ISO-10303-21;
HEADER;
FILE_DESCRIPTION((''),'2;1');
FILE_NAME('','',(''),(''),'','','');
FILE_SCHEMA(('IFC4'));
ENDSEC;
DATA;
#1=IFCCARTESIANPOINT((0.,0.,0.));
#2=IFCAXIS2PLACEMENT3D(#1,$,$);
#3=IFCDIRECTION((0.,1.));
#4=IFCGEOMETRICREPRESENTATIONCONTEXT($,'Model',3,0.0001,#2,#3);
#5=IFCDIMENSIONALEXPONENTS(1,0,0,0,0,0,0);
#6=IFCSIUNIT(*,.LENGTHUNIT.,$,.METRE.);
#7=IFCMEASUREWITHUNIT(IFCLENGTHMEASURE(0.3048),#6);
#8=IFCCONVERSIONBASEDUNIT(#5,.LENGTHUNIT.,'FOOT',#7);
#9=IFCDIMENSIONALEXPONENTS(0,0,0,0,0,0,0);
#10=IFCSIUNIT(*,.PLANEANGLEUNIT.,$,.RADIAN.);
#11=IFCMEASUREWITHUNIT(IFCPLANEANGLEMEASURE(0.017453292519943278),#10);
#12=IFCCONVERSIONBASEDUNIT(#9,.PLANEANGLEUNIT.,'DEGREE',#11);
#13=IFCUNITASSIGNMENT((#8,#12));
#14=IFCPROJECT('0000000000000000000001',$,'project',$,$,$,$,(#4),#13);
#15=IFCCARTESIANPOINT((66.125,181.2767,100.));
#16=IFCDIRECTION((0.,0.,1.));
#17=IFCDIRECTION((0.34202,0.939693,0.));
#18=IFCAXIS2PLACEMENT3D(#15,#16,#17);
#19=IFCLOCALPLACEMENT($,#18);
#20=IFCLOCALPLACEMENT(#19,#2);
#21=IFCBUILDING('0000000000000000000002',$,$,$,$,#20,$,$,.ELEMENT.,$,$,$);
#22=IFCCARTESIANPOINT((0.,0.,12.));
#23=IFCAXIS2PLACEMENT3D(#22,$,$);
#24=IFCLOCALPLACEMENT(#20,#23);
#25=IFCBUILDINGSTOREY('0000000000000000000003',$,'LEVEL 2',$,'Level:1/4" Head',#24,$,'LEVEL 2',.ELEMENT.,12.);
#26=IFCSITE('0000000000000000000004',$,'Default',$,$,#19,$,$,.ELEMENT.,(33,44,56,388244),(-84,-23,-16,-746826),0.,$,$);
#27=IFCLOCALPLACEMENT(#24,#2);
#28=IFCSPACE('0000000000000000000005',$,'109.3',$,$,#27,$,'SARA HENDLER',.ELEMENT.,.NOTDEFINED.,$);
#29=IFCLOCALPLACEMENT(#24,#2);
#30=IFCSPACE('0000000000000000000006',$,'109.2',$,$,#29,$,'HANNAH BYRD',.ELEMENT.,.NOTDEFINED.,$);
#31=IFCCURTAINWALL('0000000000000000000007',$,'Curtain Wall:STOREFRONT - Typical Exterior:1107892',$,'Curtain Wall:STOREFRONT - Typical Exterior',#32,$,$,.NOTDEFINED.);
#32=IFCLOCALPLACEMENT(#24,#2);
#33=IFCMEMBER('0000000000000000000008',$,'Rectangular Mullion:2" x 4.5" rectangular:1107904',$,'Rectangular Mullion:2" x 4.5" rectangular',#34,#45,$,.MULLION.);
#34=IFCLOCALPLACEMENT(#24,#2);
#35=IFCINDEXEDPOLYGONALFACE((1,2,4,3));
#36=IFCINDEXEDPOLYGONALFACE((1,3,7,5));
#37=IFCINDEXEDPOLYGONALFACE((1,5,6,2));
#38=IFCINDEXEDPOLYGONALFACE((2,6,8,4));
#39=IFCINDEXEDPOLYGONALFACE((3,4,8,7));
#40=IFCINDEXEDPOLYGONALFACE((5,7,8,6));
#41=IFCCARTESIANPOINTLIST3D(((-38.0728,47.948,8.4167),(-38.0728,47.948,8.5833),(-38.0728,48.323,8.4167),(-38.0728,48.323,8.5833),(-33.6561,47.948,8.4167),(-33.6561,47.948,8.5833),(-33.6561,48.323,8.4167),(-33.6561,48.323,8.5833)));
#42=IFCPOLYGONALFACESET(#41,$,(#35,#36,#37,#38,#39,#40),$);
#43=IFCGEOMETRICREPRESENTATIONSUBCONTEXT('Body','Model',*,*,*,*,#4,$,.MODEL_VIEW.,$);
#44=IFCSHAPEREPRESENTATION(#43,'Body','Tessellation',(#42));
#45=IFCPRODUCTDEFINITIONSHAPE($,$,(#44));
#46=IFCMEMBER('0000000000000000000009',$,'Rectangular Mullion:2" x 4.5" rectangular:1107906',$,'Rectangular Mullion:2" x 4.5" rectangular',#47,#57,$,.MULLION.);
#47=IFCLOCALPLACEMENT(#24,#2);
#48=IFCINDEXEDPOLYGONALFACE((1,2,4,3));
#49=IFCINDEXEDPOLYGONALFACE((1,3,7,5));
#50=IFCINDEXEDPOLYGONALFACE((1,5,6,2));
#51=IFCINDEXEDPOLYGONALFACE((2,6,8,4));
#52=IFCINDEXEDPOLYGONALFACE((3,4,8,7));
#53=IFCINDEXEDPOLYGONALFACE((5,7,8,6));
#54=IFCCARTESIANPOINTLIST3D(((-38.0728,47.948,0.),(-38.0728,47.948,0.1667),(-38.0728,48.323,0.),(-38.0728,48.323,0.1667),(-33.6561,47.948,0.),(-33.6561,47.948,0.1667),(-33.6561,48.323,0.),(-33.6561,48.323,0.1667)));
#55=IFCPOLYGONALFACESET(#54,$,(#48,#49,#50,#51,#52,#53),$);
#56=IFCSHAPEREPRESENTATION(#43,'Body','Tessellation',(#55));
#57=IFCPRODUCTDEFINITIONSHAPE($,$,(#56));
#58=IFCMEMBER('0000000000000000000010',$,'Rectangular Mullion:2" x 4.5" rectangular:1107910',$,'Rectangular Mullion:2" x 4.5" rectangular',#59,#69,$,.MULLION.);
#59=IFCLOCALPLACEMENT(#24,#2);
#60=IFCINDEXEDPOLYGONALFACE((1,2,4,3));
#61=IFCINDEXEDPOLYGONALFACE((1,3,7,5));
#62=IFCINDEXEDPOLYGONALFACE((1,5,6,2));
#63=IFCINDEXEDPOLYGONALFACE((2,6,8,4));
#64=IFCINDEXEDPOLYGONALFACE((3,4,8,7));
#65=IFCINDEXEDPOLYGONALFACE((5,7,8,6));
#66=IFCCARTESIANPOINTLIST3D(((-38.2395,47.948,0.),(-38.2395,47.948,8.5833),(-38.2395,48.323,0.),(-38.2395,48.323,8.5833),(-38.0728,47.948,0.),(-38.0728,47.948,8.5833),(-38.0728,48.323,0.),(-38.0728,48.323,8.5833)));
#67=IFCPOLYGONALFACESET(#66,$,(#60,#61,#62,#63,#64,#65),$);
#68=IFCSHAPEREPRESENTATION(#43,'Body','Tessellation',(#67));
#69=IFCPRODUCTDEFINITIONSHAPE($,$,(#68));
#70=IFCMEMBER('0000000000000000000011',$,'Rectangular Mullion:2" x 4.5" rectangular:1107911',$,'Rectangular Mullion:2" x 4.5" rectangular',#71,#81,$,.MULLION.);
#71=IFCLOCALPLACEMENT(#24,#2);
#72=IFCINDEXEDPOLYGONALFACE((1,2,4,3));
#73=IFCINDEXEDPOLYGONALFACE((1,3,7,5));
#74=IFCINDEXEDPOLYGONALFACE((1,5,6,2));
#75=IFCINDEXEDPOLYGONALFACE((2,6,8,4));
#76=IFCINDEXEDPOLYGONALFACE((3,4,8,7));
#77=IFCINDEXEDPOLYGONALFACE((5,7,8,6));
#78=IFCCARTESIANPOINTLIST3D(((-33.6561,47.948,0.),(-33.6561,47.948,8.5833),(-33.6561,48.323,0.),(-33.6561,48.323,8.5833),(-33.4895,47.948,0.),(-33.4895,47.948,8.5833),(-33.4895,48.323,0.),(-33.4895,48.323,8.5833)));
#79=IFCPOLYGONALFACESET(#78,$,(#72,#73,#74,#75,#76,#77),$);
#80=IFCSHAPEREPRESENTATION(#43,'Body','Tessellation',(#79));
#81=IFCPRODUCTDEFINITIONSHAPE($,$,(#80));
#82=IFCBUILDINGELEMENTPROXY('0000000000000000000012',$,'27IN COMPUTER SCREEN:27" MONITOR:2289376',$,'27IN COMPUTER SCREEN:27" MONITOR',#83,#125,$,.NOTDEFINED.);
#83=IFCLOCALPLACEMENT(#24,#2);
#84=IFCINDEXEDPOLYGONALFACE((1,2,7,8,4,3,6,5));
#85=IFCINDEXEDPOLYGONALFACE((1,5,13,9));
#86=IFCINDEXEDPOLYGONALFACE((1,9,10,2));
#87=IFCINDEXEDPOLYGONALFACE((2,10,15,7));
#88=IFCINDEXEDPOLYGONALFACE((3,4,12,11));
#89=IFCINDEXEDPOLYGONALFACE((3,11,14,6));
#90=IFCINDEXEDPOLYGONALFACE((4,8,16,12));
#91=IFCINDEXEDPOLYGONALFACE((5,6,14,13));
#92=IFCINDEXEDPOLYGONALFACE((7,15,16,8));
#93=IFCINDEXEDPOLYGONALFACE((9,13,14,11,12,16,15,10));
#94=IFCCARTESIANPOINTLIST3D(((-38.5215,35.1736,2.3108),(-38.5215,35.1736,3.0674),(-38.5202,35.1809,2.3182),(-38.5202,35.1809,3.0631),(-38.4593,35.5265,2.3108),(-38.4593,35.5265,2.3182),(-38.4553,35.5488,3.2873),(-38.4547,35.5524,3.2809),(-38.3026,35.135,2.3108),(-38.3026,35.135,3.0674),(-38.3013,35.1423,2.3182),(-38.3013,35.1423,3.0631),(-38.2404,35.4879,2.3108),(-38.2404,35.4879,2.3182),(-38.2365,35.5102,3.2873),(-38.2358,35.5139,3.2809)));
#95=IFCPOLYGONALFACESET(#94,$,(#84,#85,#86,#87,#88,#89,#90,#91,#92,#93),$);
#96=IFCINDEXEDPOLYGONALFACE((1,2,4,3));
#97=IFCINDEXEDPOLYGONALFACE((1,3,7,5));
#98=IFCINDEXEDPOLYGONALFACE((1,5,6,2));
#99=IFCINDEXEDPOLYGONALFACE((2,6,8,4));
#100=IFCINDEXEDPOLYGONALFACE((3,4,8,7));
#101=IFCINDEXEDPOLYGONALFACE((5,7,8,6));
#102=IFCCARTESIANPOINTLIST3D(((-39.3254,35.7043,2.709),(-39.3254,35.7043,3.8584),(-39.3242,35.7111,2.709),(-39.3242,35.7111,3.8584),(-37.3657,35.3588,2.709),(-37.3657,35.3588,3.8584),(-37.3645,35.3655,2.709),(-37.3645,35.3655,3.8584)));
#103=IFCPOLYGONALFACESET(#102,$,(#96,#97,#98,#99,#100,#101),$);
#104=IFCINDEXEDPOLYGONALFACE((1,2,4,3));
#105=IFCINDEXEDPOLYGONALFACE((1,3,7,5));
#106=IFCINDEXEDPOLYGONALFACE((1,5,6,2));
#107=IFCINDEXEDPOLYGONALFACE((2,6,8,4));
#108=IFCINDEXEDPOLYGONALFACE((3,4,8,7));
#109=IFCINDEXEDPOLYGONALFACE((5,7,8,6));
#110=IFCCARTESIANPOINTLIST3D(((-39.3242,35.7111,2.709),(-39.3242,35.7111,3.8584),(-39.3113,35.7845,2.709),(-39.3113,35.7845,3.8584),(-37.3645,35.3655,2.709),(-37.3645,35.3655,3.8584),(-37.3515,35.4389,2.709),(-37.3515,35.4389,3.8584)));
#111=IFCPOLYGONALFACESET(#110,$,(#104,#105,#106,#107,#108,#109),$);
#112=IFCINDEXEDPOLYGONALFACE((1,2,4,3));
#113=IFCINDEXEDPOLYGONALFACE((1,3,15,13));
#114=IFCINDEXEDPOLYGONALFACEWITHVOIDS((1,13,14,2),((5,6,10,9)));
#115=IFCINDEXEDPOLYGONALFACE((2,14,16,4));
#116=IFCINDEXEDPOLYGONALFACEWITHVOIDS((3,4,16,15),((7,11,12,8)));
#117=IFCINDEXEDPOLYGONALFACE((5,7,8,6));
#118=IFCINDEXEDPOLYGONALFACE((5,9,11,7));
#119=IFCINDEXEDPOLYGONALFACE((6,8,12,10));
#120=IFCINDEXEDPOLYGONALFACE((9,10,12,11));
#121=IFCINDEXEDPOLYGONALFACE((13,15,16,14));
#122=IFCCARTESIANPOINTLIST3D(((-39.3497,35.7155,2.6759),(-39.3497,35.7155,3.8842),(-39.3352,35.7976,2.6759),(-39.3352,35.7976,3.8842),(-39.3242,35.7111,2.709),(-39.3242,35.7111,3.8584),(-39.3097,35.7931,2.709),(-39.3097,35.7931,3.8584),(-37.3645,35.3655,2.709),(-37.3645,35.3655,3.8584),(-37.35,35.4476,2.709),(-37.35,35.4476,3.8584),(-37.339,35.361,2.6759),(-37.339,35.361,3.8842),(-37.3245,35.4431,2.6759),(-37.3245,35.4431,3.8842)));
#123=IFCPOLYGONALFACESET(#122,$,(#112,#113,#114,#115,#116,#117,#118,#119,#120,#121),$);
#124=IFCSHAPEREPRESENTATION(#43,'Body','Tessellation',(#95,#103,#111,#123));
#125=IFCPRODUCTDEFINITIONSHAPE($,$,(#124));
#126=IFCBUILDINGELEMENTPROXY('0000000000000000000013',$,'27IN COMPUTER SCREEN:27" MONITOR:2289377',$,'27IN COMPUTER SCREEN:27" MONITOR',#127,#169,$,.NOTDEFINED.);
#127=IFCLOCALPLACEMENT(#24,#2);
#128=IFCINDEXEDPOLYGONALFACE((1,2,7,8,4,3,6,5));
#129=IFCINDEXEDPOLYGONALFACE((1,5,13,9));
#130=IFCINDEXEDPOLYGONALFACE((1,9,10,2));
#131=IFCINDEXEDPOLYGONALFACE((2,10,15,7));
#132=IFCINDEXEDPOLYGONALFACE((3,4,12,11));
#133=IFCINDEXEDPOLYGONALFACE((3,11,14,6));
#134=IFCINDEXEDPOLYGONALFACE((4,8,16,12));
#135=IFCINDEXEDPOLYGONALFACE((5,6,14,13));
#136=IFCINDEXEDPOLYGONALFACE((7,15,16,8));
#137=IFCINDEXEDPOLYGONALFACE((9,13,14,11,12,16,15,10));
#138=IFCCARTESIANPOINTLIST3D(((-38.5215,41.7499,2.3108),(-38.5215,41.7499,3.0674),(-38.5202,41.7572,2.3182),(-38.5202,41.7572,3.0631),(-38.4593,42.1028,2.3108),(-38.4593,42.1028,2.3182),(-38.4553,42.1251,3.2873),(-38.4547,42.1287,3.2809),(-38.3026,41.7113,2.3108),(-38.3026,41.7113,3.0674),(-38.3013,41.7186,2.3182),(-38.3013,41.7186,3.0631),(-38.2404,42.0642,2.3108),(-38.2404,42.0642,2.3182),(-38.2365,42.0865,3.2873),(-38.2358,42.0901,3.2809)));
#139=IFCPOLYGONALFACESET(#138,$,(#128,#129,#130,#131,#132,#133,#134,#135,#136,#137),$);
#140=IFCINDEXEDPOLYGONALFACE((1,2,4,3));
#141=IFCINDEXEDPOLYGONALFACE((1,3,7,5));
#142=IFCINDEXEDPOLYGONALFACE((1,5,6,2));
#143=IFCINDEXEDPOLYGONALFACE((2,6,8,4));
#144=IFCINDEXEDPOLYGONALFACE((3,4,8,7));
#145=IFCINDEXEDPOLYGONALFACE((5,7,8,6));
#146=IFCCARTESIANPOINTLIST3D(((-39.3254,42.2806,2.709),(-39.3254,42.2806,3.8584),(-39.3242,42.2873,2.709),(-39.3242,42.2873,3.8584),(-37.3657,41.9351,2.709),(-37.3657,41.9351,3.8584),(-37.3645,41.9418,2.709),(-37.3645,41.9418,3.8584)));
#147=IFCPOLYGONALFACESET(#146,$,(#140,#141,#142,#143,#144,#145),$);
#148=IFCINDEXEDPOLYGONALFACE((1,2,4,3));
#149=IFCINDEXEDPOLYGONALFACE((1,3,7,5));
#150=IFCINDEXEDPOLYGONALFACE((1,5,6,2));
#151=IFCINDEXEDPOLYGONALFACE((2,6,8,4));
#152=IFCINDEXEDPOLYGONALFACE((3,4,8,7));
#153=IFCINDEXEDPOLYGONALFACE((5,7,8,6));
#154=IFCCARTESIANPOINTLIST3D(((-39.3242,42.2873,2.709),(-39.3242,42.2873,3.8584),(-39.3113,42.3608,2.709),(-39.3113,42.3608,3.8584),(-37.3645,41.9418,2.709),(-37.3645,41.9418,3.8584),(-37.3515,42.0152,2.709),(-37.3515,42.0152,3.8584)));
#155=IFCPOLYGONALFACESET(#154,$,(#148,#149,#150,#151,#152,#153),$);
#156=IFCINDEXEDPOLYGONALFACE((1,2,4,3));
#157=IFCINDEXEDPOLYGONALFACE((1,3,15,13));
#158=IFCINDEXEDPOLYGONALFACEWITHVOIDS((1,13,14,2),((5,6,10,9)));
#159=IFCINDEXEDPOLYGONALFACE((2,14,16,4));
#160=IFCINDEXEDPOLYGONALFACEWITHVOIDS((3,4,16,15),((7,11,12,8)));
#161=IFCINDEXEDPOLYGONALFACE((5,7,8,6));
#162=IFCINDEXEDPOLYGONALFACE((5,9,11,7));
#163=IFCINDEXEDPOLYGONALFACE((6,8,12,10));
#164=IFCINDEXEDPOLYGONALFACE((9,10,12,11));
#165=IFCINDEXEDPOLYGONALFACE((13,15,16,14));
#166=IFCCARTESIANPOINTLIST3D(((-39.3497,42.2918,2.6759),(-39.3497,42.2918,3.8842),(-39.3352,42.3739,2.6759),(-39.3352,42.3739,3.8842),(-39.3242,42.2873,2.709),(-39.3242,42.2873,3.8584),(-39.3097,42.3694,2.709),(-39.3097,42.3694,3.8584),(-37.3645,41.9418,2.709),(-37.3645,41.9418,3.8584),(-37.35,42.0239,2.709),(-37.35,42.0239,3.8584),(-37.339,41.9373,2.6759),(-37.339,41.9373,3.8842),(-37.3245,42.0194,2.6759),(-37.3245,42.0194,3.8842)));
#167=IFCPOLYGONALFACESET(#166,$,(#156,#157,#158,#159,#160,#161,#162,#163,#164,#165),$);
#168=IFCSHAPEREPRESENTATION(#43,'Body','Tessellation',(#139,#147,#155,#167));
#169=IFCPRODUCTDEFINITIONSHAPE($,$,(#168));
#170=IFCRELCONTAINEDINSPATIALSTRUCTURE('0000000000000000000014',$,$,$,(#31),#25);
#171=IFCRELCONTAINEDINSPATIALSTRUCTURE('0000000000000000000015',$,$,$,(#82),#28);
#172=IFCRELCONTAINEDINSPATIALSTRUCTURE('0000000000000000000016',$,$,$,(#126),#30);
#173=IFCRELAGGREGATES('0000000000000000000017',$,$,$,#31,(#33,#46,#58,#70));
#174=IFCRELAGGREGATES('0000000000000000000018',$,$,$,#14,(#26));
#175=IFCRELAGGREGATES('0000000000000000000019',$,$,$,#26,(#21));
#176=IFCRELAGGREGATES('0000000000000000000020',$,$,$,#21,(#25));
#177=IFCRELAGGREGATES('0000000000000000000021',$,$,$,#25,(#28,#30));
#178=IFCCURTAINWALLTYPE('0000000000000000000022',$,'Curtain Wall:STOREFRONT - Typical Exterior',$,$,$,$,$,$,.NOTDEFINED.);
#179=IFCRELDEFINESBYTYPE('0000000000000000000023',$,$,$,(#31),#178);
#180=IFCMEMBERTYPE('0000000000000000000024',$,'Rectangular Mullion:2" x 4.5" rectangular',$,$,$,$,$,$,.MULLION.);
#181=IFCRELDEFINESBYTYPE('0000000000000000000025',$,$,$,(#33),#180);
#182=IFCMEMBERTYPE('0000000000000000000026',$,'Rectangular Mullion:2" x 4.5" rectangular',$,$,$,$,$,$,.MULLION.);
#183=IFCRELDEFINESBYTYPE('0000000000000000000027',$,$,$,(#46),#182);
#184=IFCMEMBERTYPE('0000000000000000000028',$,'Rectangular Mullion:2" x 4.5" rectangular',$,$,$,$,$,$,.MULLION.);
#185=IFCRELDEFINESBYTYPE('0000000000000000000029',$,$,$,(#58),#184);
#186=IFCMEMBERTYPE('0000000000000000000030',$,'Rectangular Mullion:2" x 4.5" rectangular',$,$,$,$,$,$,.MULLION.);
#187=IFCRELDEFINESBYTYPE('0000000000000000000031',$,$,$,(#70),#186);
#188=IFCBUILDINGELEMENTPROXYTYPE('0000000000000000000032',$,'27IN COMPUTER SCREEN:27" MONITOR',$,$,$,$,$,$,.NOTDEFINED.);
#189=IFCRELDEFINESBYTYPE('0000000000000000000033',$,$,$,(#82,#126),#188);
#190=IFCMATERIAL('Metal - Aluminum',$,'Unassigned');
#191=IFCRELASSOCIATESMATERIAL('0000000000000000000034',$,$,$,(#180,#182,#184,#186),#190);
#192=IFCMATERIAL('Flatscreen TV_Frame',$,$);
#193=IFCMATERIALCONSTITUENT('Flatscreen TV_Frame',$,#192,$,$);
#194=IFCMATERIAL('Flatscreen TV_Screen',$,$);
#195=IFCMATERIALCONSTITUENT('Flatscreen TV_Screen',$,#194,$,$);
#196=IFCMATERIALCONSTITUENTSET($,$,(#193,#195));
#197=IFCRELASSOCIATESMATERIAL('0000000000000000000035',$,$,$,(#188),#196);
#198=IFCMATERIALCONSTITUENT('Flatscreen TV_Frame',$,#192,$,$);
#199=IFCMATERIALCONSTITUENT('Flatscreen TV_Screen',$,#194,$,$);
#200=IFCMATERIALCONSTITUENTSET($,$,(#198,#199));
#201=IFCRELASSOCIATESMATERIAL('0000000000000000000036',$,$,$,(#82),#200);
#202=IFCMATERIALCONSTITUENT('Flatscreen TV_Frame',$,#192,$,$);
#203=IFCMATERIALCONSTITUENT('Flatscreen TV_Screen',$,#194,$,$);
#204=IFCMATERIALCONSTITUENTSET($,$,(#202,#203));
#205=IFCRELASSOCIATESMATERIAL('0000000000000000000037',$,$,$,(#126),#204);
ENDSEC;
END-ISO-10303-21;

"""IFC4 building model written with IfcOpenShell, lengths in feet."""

from ifc_helpers import new_model, entity, si_unit, converted_unit, direction, frame, frame_2d, origin, origin_2d_with_axis, place, context, subcontext, project, spatial, polyline, rectangle, outline, extrude, source, transform, mapped, material, constituent, constituent_set, material_profile, profile_set, type_object, type_shapes, element, aggregate, save


model = new_model("IFC4")

# Units and contexts
model_context = context("Model", 3, precision=0.0001, world=origin(), true_north=direction((0.0, 1.0)))
body_context = subcontext(model_context, "Body", "Model", "MODEL_VIEW")
ifc_project = project(units=[converted_unit("LENGTHUNIT", "FOOT", entity("IfcLengthMeasure", 0.3048), si_unit("LENGTHUNIT", "METRE"), dimensions=[1, 0, 0, 0, 0, 0, 0]), converted_unit("PLANEANGLEUNIT", "DEGREE", entity("IfcPlaneAngleMeasure", 0.017453292519943278), si_unit("PLANEANGLEUNIT", "RADIAN"), dimensions=[0, 0, 0, 0, 0, 0, 0])], contexts=[model_context])

# Site, building, storey
site_placement = place(None, frame((66.125, 181.2767, 100.0), z_axis=(0.0, 0.0, 1.0), x_axis=(0.34202, 0.939693, 0.0)))
site = spatial("IfcSite", under=ifc_project, at=site_placement, Name="Default", CompositionType="ELEMENT", RefLatitude=(33, 44, 56, 388244), RefLongitude=(-84, -23, -16, -746826), RefElevation=0.0)
building_placement = place(site_placement, origin())
building = spatial("IfcBuilding", under=site, at=building_placement, CompositionType="ELEMENT")
storey_placement = place(building_placement, frame((0.0, 0.0, 12.0)))
storey = spatial("IfcBuildingStorey", under=building, at=storey_placement, Name="LEVEL 2", ObjectType="Level:1/4\" Head", LongName="LEVEL 2", CompositionType="ELEMENT", Elevation=12.0)

# Curtain wall, members
curtain_wall_type = type_object("IfcCurtainWallType", Name="Curtain Wall:STOREFRONT - Typical Exterior", PredefinedType="NOTDEFINED")
curtain_wall_placement = place(storey_placement, frame((0.0, 0.0, -12.0)))
curtain_wall = element("IfcCurtainWall", 1, at=curtain_wall_placement, inside=storey, type_object=curtain_wall_type, Name="Curtain Wall:STOREFRONT - Typical Exterior:1107892", ObjectType="Curtain Wall:STOREFRONT - Typical Exterior", PredefinedType="NOTDEFINED")
ifc_material_1 = material(Name="Metal - Aluminum", Category="Unassigned")
ifc_material_profile = material_profile(ifc_material_1, rectangle(XDim=0.1667, YDim=0.375, at=origin_2d_with_axis()), Name="2\" x 4.5\" rectangular")
ifc_profile_set = profile_set([ifc_material_profile], Name="2\" x 4.5\" rectangular")
member_type_1 = type_object("IfcMemberType", Name="Rectangular Mullion:2\" x 4.5\" rectangular", PredefinedType="MULLION", material=ifc_profile_set)
shared_shape_1 = source(origin(), body_context, "Body", "SweptSolid", [
    extrude(rectangle(XDim=0.1667, YDim=0.375, at=origin_2d_with_axis()), frame((-0.0833, 0.0, -4.4167), z_axis=(0.0, 0.0, 1.0), x_axis=(-1.0, 0.0, 0.0)), (0.0, 0.0, 1.0), 4.4167),
])
type_shapes(member_type_1, [shared_shape_1])
member_1_placement = place(curtain_wall_placement, frame((-33.6561, 48.1355, 20.5833), z_axis=(1.0, 0.0, 0.0), x_axis=(0.0, 0.0, 1.0)))
member_1 = element("IfcMember", 2, at=member_1_placement, type_object=member_type_1, Name="Rectangular Mullion:2\" x 4.5\" rectangular:1107904", ObjectType="Rectangular Mullion:2\" x 4.5\" rectangular", PredefinedType="MULLION", context=body_context, shape_type="MappedRepresentation", body=[
    mapped(shared_shape_1, transform((0.0, 0.0, 0.0), scale=1.0)),
])
member_type_2 = type_object("IfcMemberType", Name="Rectangular Mullion:2\" x 4.5\" rectangular", PredefinedType="MULLION", material=ifc_profile_set)
shared_shape_2 = source(origin(), body_context, "Body", "SweptSolid", [
    extrude(rectangle(XDim=0.1667, YDim=0.375, at=origin_2d_with_axis()), frame((-0.0833, 0.0, -4.4167), z_axis=(0.0, 0.0, 1.0), x_axis=(-1.0, 0.0, 0.0)), (0.0, 0.0, 1.0), 4.4167),
])
type_shapes(member_type_2, [shared_shape_2])
member_2_placement = place(curtain_wall_placement, frame((-38.0728, 48.1355, 12.0), z_axis=(-1.0, 0.0, 0.0), x_axis=(0.0, 0.0, -1.0)))
member_2 = element("IfcMember", 3, at=member_2_placement, type_object=member_type_2, Name="Rectangular Mullion:2\" x 4.5\" rectangular:1107906", ObjectType="Rectangular Mullion:2\" x 4.5\" rectangular", PredefinedType="MULLION", context=body_context, shape_type="MappedRepresentation", body=[
    mapped(shared_shape_2, transform((0.0, 0.0, 0.0), scale=1.0)),
])
member_type_3 = type_object("IfcMemberType", Name="Rectangular Mullion:2\" x 4.5\" rectangular", PredefinedType="MULLION", material=ifc_profile_set)
shared_shape_3 = source(origin(), body_context, "Body", "SweptSolid", [
    extrude(rectangle(XDim=0.1667, YDim=0.375, at=origin_2d_with_axis()), frame((-0.0833, 0.0, -8.5833), z_axis=(0.0, 0.0, 1.0), x_axis=(-1.0, 0.0, 0.0)), (0.0, 0.0, 1.0), 8.5833),
])
type_shapes(member_type_3, [shared_shape_3])
member_3_placement = place(curtain_wall_placement, frame((-38.2395, 48.1355, 20.5833), z_axis=(0.0, 0.0, 1.0), x_axis=(-1.0, 0.0, 0.0)))
member_3 = element("IfcMember", 4, at=member_3_placement, type_object=member_type_3, Name="Rectangular Mullion:2\" x 4.5\" rectangular:1107910", ObjectType="Rectangular Mullion:2\" x 4.5\" rectangular", PredefinedType="MULLION", context=body_context, shape_type="MappedRepresentation", body=[
    mapped(shared_shape_3, transform((0.0, 0.0, 0.0), scale=1.0)),
])
member_type_4 = type_object("IfcMemberType", Name="Rectangular Mullion:2\" x 4.5\" rectangular", PredefinedType="MULLION", material=ifc_profile_set)
shared_shape_4 = source(origin(), body_context, "Body", "SweptSolid", [
    extrude(rectangle(XDim=0.1667, YDim=0.375, at=frame_2d((0.0, 0.0), x_axis=(1.0, 0.0))), frame((0.0, 0.0, -8.5833), z_axis=(0.0, 0.0, 1.0), x_axis=(-1.0, 0.0, 0.0)), (0.0, 0.0, 1.0), 8.5833),
])
type_shapes(member_type_4, [shared_shape_4])
member_4_placement = place(curtain_wall_placement, frame((-33.5728, 48.1355, 12.0), z_axis=(0.0, 0.0, -1.0), x_axis=(1.0, 0.0, 0.0)))
member_4 = element("IfcMember", 5, at=member_4_placement, type_object=member_type_4, Name="Rectangular Mullion:2\" x 4.5\" rectangular:1107911", ObjectType="Rectangular Mullion:2\" x 4.5\" rectangular", PredefinedType="MULLION", context=body_context, shape_type="MappedRepresentation", body=[
    mapped(shared_shape_4, transform((0.0, 0.0, 0.0), scale=1.0)),
])
aggregate(curtain_wall, [member_1, member_2, member_3, member_4])

# Shared definitions
space_1_placement = place(storey_placement, origin())
space_1 = spatial("IfcSpace", under=storey, at=space_1_placement, Name="109.3", LongName="SARA HENDLER", CompositionType="ELEMENT", PredefinedType="NOTDEFINED")

# Shared definitions
space_2_placement = place(storey_placement, origin())
space_2 = spatial("IfcSpace", under=storey, at=space_2_placement, Name="109.2", LongName="HANNAH BYRD", CompositionType="ELEMENT", PredefinedType="NOTDEFINED")

# Building element proxies
ifc_material_2 = material(Name="Flatscreen TV_Frame")
ifc_constituent_1 = constituent(ifc_material_2, Name="Flatscreen TV_Frame")
ifc_material_3 = material(Name="Flatscreen TV_Screen")
ifc_constituent_2 = constituent(ifc_material_3, Name="Flatscreen TV_Screen")
ifc_constituent_set_1 = constituent_set(constituents=[ifc_constituent_1, ifc_constituent_2])
ifc_constituent_3 = constituent(ifc_material_2, Name="Flatscreen TV_Frame")
ifc_constituent_4 = constituent(ifc_material_3, Name="Flatscreen TV_Screen")
ifc_constituent_set_2 = constituent_set(constituents=[ifc_constituent_3, ifc_constituent_4])
building_element_proxy_type_1 = type_object("IfcBuildingElementProxyType", Name="27IN COMPUTER SCREEN:27\" MONITOR", PredefinedType="NOTDEFINED", material=ifc_constituent_set_2)
shared_shape_5 = source(origin(), body_context, "Body", "SweptSolid", [
    extrude(outline(polyline([(-0.4392, -0.3657), (-0.4392, -0.3731), (0.0007, -0.3731), (0.379, 0.2821), (0.0686, 0.4613), (0.0649, 0.4548), (0.3688, 0.2794), (-0.0036, -0.3657), (-0.4392, -0.3657)])), frame((-0.1111, -0.0264, 0.0687), z_axis=(-1.0, 0.0, 0.0), x_axis=(0.0, 0.866025, -0.5)), (0.0, 0.0, -1.0), 0.2222),
    extrude(rectangle(XDim=0.0068, YDim=1.9899, at=origin_2d_with_axis()), frame((0.0, -0.2257, 0.0331), z_axis=(0.0, 0.0, 1.0), x_axis=(0.0, 1.0, 0.0)), (0.0, 0.0, 1.0), 1.1493),
    extrude(rectangle(XDim=0.0746, YDim=1.9899, at=frame_2d((0.0, 0.0), x_axis=(1.0, 0.0))), frame((0.0, -0.2664, 0.0331), z_axis=(0.0, 0.0, 1.0), x_axis=(0.0, 1.0, 0.0)), (0.0, 0.0, 1.0), 1.1493),
    extrude(outline(polyline([(-0.6042, -1.0208), (0.6042, -1.0208), (0.6042, 1.0208), (-0.6042, 1.0208), (-0.6042, -1.0208)]), holes=[polyline([(-0.5783, -0.995), (-0.5783, 0.995), (0.571, 0.995), (0.571, -0.995), (-0.5783, -0.995)])]), frame((0.0, -0.3125, 0.6042), z_axis=(0.0, 1.0, 0.0), x_axis=(0.0, 0.0, -1.0)), (0.0, 0.0, 1.0), 0.0833),
])
type_shapes(building_element_proxy_type_1, [shared_shape_5])
proxy_1_placement = place(space_1_placement, frame((-38.3841, 35.3126, 2.6759), z_axis=(0.0, 0.0, 1.0), x_axis=(-0.984808, 0.173648, 0.0)))
element("IfcBuildingElementProxy", 6, at=proxy_1_placement, inside=space_1, type_object=building_element_proxy_type_1, material=ifc_constituent_set_1, Name="27IN COMPUTER SCREEN:27\" MONITOR:2289376", ObjectType="27IN COMPUTER SCREEN:27\" MONITOR", PredefinedType="NOTDEFINED", context=body_context, shape_type="MappedRepresentation", body=[
    mapped(shared_shape_5, transform((0.0, 0.0, 0.0), scale=1.0)),
])
ifc_constituent_5 = constituent(ifc_material_2, Name="Flatscreen TV_Frame")
ifc_constituent_6 = constituent(ifc_material_3, Name="Flatscreen TV_Screen")
ifc_constituent_set_3 = constituent_set(constituents=[ifc_constituent_5, ifc_constituent_6])
proxy_2_placement = place(space_2_placement, frame((-38.3841, 41.8889, 2.6759), z_axis=(0.0, 0.0, 1.0), x_axis=(-0.984808, 0.173648, 0.0)))
element("IfcBuildingElementProxy", 7, at=proxy_2_placement, inside=space_2, type_object=building_element_proxy_type_1, material=ifc_constituent_set_3, Name="27IN COMPUTER SCREEN:27\" MONITOR:2289377", ObjectType="27IN COMPUTER SCREEN:27\" MONITOR", PredefinedType="NOTDEFINED", context=body_context, shape_type="MappedRepresentation", body=[
    mapped(shared_shape_5, transform((0.0, 0.0, 0.0), scale=1.0)),
])

save(model, "model.ifc")
